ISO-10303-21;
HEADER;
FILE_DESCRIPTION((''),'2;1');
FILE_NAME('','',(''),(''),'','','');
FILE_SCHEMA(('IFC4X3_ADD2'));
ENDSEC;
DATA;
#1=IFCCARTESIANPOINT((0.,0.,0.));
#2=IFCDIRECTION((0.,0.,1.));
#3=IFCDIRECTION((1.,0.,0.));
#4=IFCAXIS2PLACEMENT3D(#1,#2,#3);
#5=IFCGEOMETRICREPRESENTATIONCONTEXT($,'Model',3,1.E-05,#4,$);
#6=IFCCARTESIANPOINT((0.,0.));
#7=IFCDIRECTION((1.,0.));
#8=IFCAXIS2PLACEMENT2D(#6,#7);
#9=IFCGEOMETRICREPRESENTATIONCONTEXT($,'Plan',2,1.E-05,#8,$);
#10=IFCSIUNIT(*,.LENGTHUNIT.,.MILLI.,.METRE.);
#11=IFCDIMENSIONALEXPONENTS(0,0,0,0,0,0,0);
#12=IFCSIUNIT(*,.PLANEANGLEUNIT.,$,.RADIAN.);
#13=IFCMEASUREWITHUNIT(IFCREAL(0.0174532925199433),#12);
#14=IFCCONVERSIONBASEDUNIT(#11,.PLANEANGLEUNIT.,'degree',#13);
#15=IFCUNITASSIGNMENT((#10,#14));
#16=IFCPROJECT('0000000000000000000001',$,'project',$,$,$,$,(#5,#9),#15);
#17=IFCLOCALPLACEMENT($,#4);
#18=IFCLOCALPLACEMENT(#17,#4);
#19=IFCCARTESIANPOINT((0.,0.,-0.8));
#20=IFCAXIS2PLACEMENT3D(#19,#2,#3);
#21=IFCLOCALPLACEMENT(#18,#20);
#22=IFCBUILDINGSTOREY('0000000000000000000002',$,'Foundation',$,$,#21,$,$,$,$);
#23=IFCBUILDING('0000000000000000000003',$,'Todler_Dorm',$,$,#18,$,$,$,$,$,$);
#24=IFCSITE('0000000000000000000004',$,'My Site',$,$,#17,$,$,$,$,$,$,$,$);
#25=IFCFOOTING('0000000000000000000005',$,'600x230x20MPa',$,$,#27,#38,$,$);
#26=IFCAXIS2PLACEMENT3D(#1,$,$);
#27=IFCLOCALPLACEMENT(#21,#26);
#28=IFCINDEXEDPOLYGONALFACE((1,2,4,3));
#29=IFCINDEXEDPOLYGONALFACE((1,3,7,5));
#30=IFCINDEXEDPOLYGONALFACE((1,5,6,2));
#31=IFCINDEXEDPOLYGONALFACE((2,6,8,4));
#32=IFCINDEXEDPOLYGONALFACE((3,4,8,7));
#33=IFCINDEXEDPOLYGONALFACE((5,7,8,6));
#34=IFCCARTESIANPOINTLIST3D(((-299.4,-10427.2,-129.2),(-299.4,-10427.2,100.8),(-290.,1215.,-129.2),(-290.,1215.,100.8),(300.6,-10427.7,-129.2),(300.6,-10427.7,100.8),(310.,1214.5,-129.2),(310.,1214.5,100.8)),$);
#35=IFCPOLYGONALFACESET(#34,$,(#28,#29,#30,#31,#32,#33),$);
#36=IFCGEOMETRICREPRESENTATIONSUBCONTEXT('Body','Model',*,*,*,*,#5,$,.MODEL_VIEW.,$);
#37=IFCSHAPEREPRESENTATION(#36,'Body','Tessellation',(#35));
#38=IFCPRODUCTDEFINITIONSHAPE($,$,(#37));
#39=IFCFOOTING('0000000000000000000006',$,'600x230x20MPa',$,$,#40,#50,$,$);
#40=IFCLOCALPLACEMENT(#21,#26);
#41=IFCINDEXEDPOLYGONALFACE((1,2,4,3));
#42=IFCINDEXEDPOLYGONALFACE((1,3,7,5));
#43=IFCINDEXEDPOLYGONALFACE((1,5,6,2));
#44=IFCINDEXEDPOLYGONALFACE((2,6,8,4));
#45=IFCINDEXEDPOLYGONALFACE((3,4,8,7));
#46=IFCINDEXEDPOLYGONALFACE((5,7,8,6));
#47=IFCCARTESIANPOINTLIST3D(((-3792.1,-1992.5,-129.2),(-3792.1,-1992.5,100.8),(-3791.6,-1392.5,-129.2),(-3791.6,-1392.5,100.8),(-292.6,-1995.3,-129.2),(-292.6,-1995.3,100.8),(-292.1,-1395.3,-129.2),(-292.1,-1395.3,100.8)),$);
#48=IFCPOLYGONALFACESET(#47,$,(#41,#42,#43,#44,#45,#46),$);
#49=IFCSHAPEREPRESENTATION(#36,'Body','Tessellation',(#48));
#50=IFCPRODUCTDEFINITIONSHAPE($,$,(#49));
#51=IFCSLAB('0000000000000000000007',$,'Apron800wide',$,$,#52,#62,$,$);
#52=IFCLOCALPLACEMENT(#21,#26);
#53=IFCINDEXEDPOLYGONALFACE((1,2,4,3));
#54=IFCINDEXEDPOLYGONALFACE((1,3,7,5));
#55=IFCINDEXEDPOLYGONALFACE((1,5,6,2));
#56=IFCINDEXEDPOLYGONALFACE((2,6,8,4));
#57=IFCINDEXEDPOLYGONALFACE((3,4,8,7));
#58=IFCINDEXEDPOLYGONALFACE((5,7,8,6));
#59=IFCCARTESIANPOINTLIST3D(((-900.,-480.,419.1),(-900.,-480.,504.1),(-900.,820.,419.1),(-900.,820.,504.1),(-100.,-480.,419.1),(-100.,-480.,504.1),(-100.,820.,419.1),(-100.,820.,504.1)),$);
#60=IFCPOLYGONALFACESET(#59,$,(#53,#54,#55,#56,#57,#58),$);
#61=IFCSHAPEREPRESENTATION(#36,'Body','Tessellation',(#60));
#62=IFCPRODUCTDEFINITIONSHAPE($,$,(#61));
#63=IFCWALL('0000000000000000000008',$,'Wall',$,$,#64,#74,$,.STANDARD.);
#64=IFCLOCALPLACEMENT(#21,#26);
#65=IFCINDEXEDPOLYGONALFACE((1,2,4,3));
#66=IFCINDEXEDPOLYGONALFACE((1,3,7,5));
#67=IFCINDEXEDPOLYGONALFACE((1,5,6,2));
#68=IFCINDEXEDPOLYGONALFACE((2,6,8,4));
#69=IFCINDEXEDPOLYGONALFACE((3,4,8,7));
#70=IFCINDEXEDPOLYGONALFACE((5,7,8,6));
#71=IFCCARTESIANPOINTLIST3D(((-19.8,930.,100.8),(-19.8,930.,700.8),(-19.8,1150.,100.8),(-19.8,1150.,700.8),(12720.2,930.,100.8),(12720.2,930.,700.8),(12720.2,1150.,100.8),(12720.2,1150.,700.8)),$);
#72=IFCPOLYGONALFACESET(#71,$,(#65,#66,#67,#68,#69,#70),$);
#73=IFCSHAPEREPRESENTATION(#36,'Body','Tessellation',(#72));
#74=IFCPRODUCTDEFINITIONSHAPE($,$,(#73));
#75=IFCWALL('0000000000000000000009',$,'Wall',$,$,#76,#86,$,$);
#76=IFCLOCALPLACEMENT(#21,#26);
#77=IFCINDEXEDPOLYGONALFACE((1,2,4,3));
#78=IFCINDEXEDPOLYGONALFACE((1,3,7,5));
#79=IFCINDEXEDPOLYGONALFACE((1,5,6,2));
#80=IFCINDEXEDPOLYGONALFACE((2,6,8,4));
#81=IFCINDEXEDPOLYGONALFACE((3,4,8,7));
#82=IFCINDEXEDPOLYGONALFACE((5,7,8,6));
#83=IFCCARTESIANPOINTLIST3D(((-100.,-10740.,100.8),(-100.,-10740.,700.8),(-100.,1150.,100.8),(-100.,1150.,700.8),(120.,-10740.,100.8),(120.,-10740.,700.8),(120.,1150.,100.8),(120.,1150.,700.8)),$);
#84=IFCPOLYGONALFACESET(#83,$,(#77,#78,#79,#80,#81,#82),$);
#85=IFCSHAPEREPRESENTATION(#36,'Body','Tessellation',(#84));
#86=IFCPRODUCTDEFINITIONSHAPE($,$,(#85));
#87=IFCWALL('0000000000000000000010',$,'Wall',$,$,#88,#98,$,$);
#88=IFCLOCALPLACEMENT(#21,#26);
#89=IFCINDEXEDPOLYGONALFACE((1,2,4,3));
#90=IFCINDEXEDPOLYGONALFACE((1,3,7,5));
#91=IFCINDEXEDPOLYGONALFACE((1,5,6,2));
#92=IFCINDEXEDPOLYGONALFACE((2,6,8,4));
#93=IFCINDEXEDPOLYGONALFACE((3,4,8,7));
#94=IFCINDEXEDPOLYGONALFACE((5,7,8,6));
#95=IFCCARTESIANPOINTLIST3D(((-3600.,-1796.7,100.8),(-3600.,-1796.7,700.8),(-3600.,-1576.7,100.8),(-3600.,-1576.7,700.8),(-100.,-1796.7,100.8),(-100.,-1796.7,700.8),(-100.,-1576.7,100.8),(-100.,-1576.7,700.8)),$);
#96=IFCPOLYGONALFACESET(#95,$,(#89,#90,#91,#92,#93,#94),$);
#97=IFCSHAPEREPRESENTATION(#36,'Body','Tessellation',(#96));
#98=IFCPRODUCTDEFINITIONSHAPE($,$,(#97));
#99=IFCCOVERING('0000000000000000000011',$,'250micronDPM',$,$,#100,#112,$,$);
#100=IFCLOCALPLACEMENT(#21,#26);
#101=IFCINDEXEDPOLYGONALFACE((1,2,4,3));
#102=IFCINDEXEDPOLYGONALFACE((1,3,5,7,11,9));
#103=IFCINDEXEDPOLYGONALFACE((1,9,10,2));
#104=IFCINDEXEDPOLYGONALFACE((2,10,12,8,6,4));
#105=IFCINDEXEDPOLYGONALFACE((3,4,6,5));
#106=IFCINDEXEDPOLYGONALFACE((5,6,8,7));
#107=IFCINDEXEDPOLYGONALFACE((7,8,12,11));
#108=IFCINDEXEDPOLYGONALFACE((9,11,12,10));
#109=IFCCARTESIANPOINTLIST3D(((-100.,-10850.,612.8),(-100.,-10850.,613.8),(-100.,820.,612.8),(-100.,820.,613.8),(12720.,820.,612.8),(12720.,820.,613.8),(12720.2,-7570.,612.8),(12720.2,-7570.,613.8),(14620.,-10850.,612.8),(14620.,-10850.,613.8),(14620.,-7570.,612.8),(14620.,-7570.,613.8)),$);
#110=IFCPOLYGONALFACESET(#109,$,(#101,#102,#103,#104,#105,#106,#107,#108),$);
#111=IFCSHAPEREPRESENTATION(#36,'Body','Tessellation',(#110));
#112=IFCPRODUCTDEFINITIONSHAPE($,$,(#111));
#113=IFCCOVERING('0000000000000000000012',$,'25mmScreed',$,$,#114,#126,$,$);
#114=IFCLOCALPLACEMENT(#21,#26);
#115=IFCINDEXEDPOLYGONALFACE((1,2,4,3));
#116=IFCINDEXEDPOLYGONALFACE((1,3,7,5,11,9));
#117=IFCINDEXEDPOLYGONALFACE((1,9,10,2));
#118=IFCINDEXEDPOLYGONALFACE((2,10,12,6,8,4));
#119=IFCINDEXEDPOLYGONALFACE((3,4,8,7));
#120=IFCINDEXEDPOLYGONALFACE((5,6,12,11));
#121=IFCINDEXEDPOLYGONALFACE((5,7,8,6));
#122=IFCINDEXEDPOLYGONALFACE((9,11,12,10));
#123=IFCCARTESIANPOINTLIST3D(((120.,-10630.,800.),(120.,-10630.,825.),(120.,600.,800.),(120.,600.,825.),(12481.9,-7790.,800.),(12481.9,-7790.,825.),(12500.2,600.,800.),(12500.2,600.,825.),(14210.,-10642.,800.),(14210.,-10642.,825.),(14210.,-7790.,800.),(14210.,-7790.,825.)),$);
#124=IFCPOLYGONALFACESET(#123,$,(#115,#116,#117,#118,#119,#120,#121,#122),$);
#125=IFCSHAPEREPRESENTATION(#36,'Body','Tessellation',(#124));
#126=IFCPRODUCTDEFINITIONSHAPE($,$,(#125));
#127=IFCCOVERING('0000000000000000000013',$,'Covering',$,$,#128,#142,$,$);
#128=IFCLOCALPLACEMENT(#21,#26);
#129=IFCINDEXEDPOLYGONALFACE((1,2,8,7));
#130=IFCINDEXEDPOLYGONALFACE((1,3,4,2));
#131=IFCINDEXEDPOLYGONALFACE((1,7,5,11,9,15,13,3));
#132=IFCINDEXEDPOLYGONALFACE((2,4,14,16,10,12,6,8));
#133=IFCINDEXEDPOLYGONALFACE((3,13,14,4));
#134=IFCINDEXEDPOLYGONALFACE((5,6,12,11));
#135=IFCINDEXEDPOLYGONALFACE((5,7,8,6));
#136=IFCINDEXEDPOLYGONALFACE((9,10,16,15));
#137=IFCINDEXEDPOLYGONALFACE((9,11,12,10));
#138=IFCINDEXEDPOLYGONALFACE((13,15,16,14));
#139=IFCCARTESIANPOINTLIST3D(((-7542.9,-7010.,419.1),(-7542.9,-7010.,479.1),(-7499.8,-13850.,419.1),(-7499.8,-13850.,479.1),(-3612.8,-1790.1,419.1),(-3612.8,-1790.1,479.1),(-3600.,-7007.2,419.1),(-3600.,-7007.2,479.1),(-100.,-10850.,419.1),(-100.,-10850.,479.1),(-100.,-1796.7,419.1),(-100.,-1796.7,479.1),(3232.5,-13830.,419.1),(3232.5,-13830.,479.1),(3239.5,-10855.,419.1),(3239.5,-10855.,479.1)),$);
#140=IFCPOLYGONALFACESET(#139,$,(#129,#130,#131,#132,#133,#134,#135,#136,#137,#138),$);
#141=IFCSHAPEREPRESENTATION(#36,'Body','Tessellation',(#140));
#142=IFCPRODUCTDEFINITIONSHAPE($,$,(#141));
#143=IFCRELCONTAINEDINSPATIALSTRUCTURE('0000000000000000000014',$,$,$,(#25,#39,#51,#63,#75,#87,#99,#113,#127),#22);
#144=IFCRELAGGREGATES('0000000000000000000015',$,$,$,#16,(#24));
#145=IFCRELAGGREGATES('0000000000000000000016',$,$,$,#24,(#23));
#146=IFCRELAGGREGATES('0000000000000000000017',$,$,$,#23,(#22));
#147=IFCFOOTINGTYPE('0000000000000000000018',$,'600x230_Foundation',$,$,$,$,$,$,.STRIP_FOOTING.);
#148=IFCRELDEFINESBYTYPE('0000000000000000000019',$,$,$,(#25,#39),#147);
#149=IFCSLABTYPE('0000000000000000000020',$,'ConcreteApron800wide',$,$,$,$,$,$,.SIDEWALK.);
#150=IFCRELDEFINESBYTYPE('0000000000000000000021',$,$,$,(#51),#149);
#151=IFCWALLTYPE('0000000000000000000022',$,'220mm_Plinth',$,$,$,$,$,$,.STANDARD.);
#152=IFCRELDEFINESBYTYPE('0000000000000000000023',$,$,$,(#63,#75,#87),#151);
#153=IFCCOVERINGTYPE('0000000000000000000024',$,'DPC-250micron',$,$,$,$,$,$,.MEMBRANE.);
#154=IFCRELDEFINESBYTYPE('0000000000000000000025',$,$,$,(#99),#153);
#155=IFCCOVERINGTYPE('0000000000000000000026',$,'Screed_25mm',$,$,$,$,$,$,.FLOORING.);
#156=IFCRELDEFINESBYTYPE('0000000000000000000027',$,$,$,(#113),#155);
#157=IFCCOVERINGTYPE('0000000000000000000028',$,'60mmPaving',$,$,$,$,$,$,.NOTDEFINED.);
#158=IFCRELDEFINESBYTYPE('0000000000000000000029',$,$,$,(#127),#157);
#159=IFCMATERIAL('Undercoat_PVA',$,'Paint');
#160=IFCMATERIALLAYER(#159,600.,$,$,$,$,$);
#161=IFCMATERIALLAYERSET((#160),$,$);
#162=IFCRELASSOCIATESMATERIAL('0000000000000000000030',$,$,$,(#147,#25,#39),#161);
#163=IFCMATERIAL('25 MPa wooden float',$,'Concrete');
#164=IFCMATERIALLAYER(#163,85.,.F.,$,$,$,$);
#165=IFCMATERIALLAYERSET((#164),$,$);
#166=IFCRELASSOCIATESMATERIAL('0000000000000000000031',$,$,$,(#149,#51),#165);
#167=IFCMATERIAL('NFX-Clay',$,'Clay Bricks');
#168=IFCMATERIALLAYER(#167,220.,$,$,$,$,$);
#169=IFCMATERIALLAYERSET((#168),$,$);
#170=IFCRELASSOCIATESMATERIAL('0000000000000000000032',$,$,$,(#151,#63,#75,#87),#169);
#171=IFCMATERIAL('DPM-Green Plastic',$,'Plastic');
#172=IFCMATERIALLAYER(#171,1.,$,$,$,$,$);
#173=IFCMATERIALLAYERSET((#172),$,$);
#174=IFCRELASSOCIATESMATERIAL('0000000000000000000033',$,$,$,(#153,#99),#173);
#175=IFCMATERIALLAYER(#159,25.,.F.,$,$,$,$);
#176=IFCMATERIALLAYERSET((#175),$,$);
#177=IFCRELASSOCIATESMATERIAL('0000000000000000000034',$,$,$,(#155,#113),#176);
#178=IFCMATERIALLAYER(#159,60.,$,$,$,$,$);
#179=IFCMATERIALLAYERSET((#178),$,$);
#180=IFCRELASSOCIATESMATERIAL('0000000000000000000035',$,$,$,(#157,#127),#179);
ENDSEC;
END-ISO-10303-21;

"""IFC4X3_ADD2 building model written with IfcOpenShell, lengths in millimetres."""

from ifc_helpers import new_model, entity, si_unit, converted_unit, frame, origin_with_axes, origin_2d_with_axis, place, context, subcontext, project, spatial, line, indexed_curve, outline, extrude, material, layer, layer_set, layer_usage, type_object, element, save


model = new_model("IFC4X3_ADD2")

# Units and contexts
model_context = context("Model", 3, precision=1e-05, world=origin_with_axes())
plan_context = context("Plan", 2, precision=1e-05, world=origin_2d_with_axis())
body_context = subcontext(model_context, "Body", "Model", "MODEL_VIEW")
ifc_project = project(units=[si_unit("LENGTHUNIT", "METRE", prefix="MILLI"), converted_unit("PLANEANGLEUNIT", "degree", entity("IfcReal", 0.0174532925199433), si_unit("PLANEANGLEUNIT", "RADIAN"), dimensions=[0, 0, 0, 0, 0, 0, 0])], contexts=[model_context, plan_context])

# Site, building, storey
site_placement = place(None, origin_with_axes())
site = spatial("IfcSite", under=ifc_project, at=site_placement, Name="My Site")
building_placement = place(site_placement, origin_with_axes())
building = spatial("IfcBuilding", under=site, at=building_placement, Name="Todler_Dorm")
storey_placement = place(building_placement, frame((0.0, 0.0, -0.8), z_axis=(0.0, 0.0, 1.0), x_axis=(1.0, 0.0, 0.0)))
storey = spatial("IfcBuildingStorey", under=building, at=storey_placement, Name="Foundation")

# Footings
ifc_material_1 = material(Name="Undercoat_PVA", Category="Paint")
ifc_layer_1 = layer(ifc_material_1, 600.0)
ifc_layer_set_1 = layer_set([ifc_layer_1])
ifc_layer_usage_1 = layer_usage(ifc_layer_set_1, "AXIS2", "POSITIVE", 0.0)
footing_type = type_object("IfcFootingType", Name="600x230_Foundation", PredefinedType="STRIP_FOOTING", material=ifc_layer_set_1)
footing_1_placement = place(storey_placement, frame((-290.0, 1215.0, -129.2), z_axis=(0.0, 0.0, 1.0), x_axis=(-0.000807, -1.0, 0.0)))
element("IfcFooting", 1, at=footing_1_placement, inside=storey, type_object=footing_type, material=ifc_layer_usage_1, Name="600x230x20MPa", context=body_context, shape_type="SweptSolid", body=[
    extrude(outline(indexed_curve([(0.0, 0.0), (0.0, 600.0), (11642.2, 600.0), (11642.2, 0.0)], segments=[line(1, 2, 3, 4, 1)])), origin_with_axes(), (0.0, 0.0, 1.0), 230.0),
])
ifc_layer_usage_2 = layer_usage(ifc_layer_set_1, "AXIS2", "POSITIVE", 0.0)
footing_2_placement = place(storey_placement, frame((-3792.1, -1992.5, -129.2), z_axis=(0.0, 0.0, 1.0), x_axis=(1.0, -0.000807, 0.0)))
element("IfcFooting", 2, at=footing_2_placement, inside=storey, type_object=footing_type, material=ifc_layer_usage_2, Name="600x230x20MPa", context=body_context, shape_type="SweptSolid", body=[
    extrude(outline(indexed_curve([(0.0, 0.0), (0.0, 600.0), (3499.5, 600.0), (3499.5, 0.0)], segments=[line(1, 2, 3, 4, 1)])), origin_with_axes(), (0.0, 0.0, 1.0), 230.0),
])

# Slab
ifc_material_2 = material(Name="25 MPa wooden float", Category="Concrete")
ifc_layer_2 = layer(ifc_material_2, 85.0, ventilated=False)
ifc_layer_set_2 = layer_set([ifc_layer_2])
slab_type_1 = type_object("IfcSlabType", Name="ConcreteApron800wide", PredefinedType="SIDEWALK", material=ifc_layer_set_2)
ifc_layer_usage_3 = layer_usage(ifc_layer_set_2, "AXIS3", "POSITIVE", -100.0)
slab_1_placement = place(storey_placement, frame((-100.0, 820.0, 519.1), z_axis=(0.0, 0.0, 1.0), x_axis=(0.0, 1.0, 0.0)))
element("IfcSlab", 3, at=slab_1_placement, inside=storey, type_object=slab_type_1, material=ifc_layer_usage_3, Name="Apron800wide", context=body_context, shape_type="SweptSolid", body=[
    extrude(outline(indexed_curve([(-1300.0, 0.0), (-1300.0, 800.0), (0.0, 800.0), (0.0, 0.0), (-1300.0, 0.0)])), frame((0.0, 0.0, -100.0), z_axis=(0.0, 0.0, 1.0), x_axis=(1.0, 0.0, 0.0)), (0.0, 0.0, 1.0), 85.0),
])

# Walls
ifc_material_3 = material(Name="NFX-Clay", Category="Clay Bricks")
ifc_layer_3 = layer(ifc_material_3, 220.0)
ifc_layer_set_3 = layer_set([ifc_layer_3])
ifc_layer_usage_4 = layer_usage(ifc_layer_set_3, "AXIS2", "POSITIVE", 0.0)
wall_type = type_object("IfcWallType", Name="220mm_Plinth", PredefinedType="STANDARD", material=ifc_layer_set_3)
wall_1_placement = place(storey_placement, frame((-19.8, 930.0, 100.8), z_axis=(0.0, 0.0, 1.0), x_axis=(1.0, 0.0, 0.0)))
element("IfcWall", 4, at=wall_1_placement, inside=storey, type_object=wall_type, material=ifc_layer_usage_4, Name="Wall", PredefinedType="STANDARD", context=body_context, shape_type="SweptSolid", body=[
    extrude(outline(indexed_curve([(0.0, 0.0), (0.0, 220.0), (12740.0, 220.0), (12740.0, 0.0)], segments=[line(1, 2, 3, 4, 1)])), origin_with_axes(), (0.0, 0.0, 1.0), 600.0),
])
ifc_layer_usage_5 = layer_usage(ifc_layer_set_3, "AXIS2", "POSITIVE", 0.0)
wall_2_placement = place(storey_placement, frame((120.0, -10740.0, 100.8), z_axis=(0.0, 0.0, 1.0), x_axis=(0.0, 1.0, 0.0)))
element("IfcWall", 5, at=wall_2_placement, inside=storey, type_object=wall_type, material=ifc_layer_usage_5, Name="Wall", context=body_context, shape_type="SweptSolid", body=[
    extrude(outline(indexed_curve([(0.0, 0.0), (0.0, 220.0), (11890.0, 220.0), (11890.0, 0.0)], segments=[line(1, 2, 3, 4, 1)])), origin_with_axes(), (0.0, 0.0, 1.0), 600.0),
])
ifc_layer_usage_6 = layer_usage(ifc_layer_set_3, "AXIS2", "POSITIVE", 0.0)
wall_3_placement = place(storey_placement, frame((-3600.0, -1796.7, 100.8), z_axis=(0.0, 0.0, 1.0), x_axis=(1.0, 0.0, 0.0)))
element("IfcWall", 6, at=wall_3_placement, inside=storey, type_object=wall_type, material=ifc_layer_usage_6, Name="Wall", context=body_context, shape_type="SweptSolid", body=[
    extrude(outline(indexed_curve([(0.0, 0.0), (0.0, 220.0), (3500.0, 220.0), (3500.0, 0.0)], segments=[line(1, 2, 3, 4, 1)])), origin_with_axes(), (0.0, 0.0, 1.0), 600.0),
])

# Coverings
ifc_material_4 = material(Name="DPM-Green Plastic", Category="Plastic")
ifc_layer_4 = layer(ifc_material_4, 1.0)
ifc_layer_set_4 = layer_set([ifc_layer_4])
ifc_layer_usage_7 = layer_usage(ifc_layer_set_4, "AXIS3", "POSITIVE", -1.0)
covering_type_1 = type_object("IfcCoveringType", Name="DPC-250micron", PredefinedType="MEMBRANE", material=ifc_layer_set_4)
covering_1_placement = place(storey_placement, frame((-100.0, 820.0, 613.8), z_axis=(0.0, 0.0, 1.0), x_axis=(1.0, 0.0, 0.0)))
element("IfcCovering", 7, at=covering_1_placement, inside=storey, type_object=covering_type_1, material=ifc_layer_usage_7, Name="250micronDPM", context=body_context, shape_type="SweptSolid", body=[
    extrude(outline(indexed_curve([(0.0, 0.0), (12820.0, 0.0), (12820.2, -8390.0), (14720.0, -8390.0), (14720.0, -11670.0), (0.0, -11670.0), (0.0, 0.0)])), frame((0.0, 0.0, -1.0), z_axis=(0.0, 0.0, 1.0), x_axis=(1.0, 0.0, 0.0)), (0.0, 0.0, 1.0), 1.0),
])
ifc_layer_5 = layer(ifc_material_1, 25.0, ventilated=False)
ifc_layer_set_5 = layer_set([ifc_layer_5])
ifc_layer_usage_8 = layer_usage(ifc_layer_set_5, "AXIS3", "POSITIVE", 0.0)
covering_type_2 = type_object("IfcCoveringType", Name="Screed_25mm", PredefinedType="FLOORING", material=ifc_layer_set_5)
covering_2_placement = place(storey_placement, frame((120.0, -10630.0, 800.0), z_axis=(0.0, 0.0, 1.0), x_axis=(1.0, 0.0, 0.0)))
element("IfcCovering", 8, at=covering_2_placement, inside=storey, type_object=covering_type_2, material=ifc_layer_usage_8, Name="25mmScreed", context=body_context, shape_type="SweptSolid", body=[
    extrude(outline(indexed_curve([(14090.0, -12.0), (14090.0, 2840.0), (12361.9, 2840.0), (12380.2, 11230.0), (0.0, 11230.0), (0.0, 0.0), (14090.0, -12.0)])), None, (0.0, 0.0, 1.0), 25.0),
])
ifc_layer_6 = layer(ifc_material_1, 60.0)
ifc_layer_set_6 = layer_set([ifc_layer_6])
ifc_layer_usage_9 = layer_usage(ifc_layer_set_6, "AXIS3", "POSITIVE", -60.0)
covering_type_3 = type_object("IfcCoveringType", Name="60mmPaving", PredefinedType="NOTDEFINED", material=ifc_layer_set_6)
covering_3_placement = place(storey_placement, frame((-3612.8, -1790.1, 479.1), z_axis=(0.0, 0.0, 1.0), x_axis=(1.0, 0.0, 0.0)))
element("IfcCovering", 9, at=covering_3_placement, inside=storey, type_object=covering_type_3, material=ifc_layer_usage_9, Name="Covering", context=body_context, shape_type="SweptSolid", body=[
    extrude(outline(indexed_curve([(12.8, -5217.1), (-3930.1, -5219.9), (-3887.0, -12060.0), (6845.3, -12039.9), (6852.3, -9064.9), (3512.8, -9059.9), (3512.8, -6.6), (0.0, 0.0), (12.8, -5217.1)])), frame((0.0, 0.0, -60.0), z_axis=(0.0, 0.0, 1.0), x_axis=(1.0, 0.0, 0.0)), (0.0, 0.0, 1.0), 60.0),
])

save(model, "model.ifc")
